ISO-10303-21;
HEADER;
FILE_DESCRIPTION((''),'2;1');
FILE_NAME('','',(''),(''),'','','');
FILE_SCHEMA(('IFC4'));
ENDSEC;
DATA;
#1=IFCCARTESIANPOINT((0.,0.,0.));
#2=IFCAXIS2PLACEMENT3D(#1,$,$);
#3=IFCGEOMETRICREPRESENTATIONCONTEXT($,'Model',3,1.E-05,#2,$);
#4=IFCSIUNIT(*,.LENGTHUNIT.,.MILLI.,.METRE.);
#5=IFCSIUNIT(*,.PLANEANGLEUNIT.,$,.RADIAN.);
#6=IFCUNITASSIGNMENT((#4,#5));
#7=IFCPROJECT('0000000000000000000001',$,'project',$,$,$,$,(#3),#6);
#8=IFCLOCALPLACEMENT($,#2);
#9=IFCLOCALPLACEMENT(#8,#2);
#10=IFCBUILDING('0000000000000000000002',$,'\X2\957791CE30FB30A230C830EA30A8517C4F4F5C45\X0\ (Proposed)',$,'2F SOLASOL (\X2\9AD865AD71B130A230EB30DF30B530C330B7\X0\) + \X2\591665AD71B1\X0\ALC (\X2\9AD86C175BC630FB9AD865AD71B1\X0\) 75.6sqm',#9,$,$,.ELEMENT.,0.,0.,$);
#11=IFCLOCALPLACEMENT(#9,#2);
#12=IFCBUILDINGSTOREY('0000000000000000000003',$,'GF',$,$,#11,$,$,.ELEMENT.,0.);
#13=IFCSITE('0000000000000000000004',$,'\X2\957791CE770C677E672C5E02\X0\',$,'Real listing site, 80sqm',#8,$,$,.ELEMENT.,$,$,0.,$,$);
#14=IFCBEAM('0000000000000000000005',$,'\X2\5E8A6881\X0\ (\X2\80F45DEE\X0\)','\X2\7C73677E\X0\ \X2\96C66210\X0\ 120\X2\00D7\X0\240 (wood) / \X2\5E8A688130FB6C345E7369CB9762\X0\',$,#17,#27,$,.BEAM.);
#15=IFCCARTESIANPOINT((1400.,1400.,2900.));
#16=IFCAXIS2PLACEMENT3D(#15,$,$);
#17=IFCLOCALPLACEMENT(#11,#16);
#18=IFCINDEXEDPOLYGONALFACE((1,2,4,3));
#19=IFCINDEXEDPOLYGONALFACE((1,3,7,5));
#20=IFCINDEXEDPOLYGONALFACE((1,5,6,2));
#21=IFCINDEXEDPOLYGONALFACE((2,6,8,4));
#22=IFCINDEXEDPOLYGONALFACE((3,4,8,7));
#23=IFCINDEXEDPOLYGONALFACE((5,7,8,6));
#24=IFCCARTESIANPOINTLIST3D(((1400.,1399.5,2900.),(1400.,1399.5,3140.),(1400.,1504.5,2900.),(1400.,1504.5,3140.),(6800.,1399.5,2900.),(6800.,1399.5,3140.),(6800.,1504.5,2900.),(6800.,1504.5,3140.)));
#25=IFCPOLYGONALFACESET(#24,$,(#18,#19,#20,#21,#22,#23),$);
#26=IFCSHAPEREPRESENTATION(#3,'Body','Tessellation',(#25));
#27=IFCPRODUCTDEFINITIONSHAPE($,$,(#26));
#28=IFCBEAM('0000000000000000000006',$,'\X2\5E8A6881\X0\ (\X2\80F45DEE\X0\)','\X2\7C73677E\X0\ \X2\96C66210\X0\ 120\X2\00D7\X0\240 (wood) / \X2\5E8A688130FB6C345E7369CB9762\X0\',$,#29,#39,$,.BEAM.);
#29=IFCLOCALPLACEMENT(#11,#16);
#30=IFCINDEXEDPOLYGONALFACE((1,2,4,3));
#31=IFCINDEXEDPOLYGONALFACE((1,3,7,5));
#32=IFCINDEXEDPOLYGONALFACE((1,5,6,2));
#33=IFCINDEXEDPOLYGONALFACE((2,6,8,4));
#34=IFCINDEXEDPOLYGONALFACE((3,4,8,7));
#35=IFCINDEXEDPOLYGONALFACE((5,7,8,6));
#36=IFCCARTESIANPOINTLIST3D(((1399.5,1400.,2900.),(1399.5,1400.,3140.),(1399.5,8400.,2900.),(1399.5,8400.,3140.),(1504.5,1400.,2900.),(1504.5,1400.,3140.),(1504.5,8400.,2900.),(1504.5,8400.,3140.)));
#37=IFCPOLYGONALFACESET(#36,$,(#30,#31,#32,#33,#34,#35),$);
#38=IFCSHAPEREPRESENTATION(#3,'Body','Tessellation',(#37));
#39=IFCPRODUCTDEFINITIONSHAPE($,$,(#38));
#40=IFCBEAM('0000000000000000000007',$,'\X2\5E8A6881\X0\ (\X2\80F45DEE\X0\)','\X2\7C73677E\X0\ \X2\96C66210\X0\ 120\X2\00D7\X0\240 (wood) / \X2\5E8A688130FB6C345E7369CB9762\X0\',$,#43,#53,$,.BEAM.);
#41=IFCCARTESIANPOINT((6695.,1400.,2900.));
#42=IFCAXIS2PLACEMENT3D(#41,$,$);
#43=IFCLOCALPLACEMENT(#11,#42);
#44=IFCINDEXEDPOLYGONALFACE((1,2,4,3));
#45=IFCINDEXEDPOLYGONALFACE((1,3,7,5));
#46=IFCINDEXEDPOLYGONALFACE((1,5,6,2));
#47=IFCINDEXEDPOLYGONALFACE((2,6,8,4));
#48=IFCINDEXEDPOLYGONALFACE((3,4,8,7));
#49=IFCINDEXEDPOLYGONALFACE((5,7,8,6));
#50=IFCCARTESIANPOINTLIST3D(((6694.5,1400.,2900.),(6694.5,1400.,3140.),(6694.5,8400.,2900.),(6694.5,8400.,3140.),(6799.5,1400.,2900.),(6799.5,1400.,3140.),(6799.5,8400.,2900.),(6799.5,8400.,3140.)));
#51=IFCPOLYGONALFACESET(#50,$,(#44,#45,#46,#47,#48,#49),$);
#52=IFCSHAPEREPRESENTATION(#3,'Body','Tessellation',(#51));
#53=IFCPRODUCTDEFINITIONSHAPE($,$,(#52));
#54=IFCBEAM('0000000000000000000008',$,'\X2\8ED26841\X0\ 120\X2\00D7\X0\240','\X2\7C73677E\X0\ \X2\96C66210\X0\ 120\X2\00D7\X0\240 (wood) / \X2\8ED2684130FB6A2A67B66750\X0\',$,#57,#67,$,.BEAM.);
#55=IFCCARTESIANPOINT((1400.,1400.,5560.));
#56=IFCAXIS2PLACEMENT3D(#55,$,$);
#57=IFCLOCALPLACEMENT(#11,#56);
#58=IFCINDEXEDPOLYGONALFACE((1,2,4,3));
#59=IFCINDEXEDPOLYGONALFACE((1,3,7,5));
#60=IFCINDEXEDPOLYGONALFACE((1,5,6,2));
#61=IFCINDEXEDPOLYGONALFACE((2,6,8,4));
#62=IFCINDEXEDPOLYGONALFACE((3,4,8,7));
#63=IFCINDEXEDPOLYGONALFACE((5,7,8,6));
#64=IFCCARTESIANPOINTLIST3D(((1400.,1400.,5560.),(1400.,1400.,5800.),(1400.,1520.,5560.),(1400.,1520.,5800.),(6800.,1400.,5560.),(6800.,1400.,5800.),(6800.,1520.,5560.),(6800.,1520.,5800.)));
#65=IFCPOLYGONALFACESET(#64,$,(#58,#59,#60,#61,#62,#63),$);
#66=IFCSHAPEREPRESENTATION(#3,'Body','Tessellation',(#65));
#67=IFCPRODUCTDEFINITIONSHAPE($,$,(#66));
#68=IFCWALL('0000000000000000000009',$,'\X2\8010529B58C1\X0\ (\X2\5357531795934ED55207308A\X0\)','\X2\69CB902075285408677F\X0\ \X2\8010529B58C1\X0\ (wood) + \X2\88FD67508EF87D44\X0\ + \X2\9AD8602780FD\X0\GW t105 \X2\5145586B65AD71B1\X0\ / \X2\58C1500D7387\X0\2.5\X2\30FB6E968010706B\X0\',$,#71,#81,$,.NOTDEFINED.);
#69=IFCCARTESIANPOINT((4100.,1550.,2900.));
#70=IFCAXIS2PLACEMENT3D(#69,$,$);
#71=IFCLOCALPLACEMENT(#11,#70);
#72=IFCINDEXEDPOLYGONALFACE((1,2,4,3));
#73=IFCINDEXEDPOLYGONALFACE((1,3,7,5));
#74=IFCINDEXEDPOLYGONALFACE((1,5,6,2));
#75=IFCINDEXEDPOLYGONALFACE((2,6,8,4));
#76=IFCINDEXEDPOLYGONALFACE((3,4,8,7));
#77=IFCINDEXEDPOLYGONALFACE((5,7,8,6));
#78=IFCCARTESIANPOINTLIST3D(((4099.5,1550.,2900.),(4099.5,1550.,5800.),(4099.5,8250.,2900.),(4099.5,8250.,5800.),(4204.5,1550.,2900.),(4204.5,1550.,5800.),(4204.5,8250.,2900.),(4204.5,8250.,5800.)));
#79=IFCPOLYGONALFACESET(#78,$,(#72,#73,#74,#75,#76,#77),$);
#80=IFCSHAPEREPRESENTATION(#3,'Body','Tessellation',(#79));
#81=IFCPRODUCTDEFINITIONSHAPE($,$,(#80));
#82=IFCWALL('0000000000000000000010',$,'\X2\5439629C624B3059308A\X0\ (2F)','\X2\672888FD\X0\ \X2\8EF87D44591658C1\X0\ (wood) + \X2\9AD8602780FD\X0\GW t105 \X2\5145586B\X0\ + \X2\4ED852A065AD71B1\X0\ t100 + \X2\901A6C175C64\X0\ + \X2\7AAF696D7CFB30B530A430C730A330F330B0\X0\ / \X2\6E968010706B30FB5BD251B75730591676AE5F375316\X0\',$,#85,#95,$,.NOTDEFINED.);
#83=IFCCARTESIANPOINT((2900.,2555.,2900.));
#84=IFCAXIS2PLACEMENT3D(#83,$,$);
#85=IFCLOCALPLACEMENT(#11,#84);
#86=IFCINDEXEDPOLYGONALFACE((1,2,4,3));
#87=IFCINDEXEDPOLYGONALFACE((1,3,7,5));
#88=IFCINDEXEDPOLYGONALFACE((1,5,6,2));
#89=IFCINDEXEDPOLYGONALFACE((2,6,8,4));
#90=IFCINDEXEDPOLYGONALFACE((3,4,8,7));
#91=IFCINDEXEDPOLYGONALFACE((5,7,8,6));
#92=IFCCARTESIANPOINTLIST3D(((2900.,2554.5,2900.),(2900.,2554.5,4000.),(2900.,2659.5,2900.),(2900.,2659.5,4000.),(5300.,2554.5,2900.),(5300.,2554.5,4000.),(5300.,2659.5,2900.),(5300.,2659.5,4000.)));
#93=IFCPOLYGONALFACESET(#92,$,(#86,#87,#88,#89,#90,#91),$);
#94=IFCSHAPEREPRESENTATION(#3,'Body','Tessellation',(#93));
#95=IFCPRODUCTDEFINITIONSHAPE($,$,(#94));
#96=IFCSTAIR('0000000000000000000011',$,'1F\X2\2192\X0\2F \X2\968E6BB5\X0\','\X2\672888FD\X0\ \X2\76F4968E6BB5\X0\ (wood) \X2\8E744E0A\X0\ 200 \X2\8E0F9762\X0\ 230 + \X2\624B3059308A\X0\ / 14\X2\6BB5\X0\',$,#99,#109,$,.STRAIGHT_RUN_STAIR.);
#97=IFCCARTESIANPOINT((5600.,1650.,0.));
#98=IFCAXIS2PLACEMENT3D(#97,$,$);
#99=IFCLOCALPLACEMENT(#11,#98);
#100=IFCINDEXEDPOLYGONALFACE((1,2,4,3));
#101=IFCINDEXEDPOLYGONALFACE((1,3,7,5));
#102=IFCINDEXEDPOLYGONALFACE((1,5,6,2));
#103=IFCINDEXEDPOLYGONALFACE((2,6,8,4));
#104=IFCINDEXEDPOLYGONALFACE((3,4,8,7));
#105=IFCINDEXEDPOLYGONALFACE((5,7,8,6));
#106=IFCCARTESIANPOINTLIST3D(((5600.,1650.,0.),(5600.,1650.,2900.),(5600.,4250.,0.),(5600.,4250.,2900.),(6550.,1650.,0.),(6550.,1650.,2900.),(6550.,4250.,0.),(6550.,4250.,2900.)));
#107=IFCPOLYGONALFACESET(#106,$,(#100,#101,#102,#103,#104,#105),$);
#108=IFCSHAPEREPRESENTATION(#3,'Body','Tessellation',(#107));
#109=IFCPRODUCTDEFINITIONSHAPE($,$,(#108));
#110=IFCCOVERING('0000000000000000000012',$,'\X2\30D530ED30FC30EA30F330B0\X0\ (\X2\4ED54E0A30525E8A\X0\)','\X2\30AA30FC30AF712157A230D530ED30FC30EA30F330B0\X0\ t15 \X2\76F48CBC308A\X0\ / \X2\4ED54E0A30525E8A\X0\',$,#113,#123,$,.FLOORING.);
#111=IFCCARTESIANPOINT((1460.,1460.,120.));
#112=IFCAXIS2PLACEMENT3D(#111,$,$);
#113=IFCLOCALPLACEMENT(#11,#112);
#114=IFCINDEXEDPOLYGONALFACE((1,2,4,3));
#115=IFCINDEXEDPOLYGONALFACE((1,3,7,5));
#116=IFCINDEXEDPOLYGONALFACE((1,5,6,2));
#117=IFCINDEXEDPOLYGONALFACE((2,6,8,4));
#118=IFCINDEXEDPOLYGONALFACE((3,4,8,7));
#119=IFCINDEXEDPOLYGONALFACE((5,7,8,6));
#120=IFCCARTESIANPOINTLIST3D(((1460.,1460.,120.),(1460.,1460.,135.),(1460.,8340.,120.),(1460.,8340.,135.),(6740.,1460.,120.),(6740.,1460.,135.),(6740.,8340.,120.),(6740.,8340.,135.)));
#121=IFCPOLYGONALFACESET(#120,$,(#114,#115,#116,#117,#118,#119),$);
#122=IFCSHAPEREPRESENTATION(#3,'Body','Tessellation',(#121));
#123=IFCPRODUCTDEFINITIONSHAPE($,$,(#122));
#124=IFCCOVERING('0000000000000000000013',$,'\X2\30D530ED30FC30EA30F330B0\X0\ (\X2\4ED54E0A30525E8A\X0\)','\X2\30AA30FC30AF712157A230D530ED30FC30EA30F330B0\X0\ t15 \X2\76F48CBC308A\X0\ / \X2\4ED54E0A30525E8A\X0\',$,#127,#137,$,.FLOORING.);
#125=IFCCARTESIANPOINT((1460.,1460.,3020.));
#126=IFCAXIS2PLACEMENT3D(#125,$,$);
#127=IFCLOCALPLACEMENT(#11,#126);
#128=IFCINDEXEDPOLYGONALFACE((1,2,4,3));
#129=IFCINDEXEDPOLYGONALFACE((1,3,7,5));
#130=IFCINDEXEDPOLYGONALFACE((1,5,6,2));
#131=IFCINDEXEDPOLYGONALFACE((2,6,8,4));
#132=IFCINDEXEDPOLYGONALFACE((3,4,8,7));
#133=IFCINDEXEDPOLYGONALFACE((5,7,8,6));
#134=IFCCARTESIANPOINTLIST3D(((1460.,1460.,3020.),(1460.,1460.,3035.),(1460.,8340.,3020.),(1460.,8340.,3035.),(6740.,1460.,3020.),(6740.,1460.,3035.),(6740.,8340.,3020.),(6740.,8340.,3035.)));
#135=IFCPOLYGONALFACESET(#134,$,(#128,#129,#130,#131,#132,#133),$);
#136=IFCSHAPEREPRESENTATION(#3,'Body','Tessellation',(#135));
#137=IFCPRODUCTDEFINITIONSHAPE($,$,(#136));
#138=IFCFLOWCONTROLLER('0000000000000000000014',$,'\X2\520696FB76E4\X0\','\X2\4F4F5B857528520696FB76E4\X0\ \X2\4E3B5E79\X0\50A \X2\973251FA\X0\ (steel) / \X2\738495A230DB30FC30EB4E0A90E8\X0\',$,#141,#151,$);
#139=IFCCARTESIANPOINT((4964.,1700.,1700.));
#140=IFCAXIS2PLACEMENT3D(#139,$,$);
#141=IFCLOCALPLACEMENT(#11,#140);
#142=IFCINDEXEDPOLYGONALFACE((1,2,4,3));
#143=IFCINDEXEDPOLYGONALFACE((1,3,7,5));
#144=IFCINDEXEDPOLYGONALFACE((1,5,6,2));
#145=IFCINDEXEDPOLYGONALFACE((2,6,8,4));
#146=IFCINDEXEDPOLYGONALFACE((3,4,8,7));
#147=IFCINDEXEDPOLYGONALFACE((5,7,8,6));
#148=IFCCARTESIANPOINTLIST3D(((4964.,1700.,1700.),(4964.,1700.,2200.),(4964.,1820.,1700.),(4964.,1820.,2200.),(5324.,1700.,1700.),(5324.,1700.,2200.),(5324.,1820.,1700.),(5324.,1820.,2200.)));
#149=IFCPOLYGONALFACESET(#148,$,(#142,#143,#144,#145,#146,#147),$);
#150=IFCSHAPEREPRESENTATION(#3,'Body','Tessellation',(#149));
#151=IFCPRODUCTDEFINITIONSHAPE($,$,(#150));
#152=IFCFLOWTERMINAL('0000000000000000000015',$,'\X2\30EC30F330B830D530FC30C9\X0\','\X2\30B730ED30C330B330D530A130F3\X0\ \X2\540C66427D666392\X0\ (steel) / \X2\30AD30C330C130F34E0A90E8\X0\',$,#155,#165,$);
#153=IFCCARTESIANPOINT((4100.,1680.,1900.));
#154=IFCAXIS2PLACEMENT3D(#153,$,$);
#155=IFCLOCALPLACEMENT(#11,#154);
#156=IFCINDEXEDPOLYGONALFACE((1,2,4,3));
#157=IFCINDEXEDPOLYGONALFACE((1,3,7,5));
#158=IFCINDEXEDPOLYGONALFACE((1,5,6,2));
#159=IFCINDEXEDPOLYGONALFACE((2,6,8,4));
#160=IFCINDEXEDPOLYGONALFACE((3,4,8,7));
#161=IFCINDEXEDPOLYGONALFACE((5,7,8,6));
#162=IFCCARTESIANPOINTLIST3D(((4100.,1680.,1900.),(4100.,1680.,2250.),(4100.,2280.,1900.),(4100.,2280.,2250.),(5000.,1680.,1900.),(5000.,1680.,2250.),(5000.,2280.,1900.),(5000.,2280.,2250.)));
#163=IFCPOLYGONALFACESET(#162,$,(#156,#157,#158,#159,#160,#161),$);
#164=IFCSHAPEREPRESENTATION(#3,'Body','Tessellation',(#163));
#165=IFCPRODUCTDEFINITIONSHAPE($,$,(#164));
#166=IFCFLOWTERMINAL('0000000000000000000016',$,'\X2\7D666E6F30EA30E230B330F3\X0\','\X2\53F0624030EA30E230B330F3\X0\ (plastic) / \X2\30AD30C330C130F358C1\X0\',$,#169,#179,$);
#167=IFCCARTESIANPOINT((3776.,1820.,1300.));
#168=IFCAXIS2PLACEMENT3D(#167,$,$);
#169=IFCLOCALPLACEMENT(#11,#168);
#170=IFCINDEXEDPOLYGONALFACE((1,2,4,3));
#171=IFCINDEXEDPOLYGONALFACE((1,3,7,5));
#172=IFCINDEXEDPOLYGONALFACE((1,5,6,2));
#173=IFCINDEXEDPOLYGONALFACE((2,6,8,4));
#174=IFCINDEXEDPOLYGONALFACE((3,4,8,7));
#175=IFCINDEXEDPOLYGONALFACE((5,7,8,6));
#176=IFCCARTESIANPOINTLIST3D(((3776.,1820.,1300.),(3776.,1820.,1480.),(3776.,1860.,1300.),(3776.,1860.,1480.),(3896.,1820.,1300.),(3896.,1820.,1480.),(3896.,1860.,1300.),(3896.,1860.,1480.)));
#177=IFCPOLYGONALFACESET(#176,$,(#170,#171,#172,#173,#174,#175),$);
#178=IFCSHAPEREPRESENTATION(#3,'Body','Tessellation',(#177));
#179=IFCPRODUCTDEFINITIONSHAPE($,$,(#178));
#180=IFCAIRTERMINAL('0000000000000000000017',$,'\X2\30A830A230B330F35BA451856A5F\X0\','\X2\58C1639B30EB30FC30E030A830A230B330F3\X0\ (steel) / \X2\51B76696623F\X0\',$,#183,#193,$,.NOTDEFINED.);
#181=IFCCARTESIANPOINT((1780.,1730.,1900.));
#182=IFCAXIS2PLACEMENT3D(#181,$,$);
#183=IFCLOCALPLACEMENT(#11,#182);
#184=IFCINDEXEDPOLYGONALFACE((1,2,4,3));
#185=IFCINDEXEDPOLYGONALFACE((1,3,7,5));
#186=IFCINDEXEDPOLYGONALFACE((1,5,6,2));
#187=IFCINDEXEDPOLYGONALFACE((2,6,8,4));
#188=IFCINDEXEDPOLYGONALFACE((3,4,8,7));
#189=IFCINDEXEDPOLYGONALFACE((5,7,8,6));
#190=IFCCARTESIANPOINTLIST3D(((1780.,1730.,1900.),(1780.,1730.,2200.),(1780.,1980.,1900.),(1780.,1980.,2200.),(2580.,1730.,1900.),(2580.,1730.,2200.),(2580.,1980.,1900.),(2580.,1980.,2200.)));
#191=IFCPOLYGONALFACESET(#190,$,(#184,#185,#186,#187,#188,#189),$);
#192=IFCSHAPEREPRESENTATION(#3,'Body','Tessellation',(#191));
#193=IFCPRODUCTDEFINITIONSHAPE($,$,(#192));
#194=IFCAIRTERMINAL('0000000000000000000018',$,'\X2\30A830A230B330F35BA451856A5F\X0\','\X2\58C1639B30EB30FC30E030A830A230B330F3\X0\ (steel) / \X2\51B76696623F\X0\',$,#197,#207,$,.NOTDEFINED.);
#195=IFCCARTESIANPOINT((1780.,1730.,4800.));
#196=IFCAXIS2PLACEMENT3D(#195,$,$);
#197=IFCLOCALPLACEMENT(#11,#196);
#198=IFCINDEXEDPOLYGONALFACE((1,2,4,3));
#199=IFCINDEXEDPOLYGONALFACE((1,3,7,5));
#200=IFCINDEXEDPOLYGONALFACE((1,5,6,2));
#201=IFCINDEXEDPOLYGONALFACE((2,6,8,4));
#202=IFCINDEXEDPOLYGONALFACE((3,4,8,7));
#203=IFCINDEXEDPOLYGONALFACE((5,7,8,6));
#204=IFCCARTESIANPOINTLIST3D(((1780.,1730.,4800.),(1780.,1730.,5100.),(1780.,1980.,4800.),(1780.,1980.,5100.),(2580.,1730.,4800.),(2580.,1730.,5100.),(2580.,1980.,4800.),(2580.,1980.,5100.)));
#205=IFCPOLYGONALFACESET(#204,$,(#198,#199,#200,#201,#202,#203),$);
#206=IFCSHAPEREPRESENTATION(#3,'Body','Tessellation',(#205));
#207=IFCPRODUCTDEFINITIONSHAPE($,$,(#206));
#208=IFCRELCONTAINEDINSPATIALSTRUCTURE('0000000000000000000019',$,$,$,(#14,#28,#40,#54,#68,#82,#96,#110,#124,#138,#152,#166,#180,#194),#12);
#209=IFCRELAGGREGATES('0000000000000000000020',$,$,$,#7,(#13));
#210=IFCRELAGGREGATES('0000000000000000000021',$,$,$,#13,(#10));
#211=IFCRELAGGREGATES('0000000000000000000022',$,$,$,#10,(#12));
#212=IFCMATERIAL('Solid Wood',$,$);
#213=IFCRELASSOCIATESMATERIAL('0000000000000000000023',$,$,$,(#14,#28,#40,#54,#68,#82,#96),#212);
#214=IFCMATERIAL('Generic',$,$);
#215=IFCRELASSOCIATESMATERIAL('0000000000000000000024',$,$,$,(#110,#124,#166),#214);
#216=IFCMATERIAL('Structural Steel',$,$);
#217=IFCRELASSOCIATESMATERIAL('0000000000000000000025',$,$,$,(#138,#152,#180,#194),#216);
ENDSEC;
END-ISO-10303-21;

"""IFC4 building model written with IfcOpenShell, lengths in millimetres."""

from ifc_helpers import new_model, si_unit, frame, frame_2d, origin, place, context, project, spatial, rectangle, extrude, material, element, save


model = new_model("IFC4")

# Units and contexts
model_context = context("Model", 3, precision=1e-05, world=origin())
ifc_project = project(units=[si_unit("LENGTHUNIT", "METRE", prefix="MILLI"), si_unit("PLANEANGLEUNIT", "RADIAN")], contexts=[model_context])

# Site, building, storey
site_placement = place(None, origin())
site = spatial("IfcSite", under=ifc_project, at=site_placement, Name="長野県松本市", ObjectType="Real listing site, 80sqm", CompositionType="ELEMENT", RefElevation=0.0)
building_placement = place(site_placement, origin())
building = spatial("IfcBuilding", under=site, at=building_placement, Name="長野・アトリエ兼住居 (Proposed)", ObjectType="2F SOLASOL (高断熱アルミサッシ) + 外断熱ALC (高気密・高断熱) 75.6sqm", CompositionType="ELEMENT", ElevationOfRefHeight=0.0, ElevationOfTerrain=0.0)
storey_placement = place(building_placement, origin())
storey = spatial("IfcBuildingStorey", under=building, at=storey_placement, Name="GF", CompositionType="ELEMENT", Elevation=0.0)

# Shared definitions
ifc_material_1 = material(Name="Solid Wood")

# Beams
beam_1_placement = place(storey_placement, frame((1400.0, 1400.0, 2900.0)))
element("IfcBeam", 1, at=beam_1_placement, inside=storey, material=ifc_material_1, Name="床梁 (胴差)", Description="米松 集成 120×240 (wood) / 床梁・水平構面", PredefinedType="BEAM", context=model_context, shape_type="SweptSolid", body=[
    extrude(rectangle(XDim=5400.0, YDim=105.0, at=frame_2d((2700.0, 52.0))), frame((1400.0, 1400.0, 2900.0)), (0.0, 0.0, 1.0), 240.0),
])
beam_2_placement = place(storey_placement, frame((1400.0, 1400.0, 2900.0)))
element("IfcBeam", 2, at=beam_2_placement, inside=storey, material=ifc_material_1, Name="床梁 (胴差)", Description="米松 集成 120×240 (wood) / 床梁・水平構面", PredefinedType="BEAM", context=model_context, shape_type="SweptSolid", body=[
    extrude(rectangle(XDim=105.0, YDim=7000.0, at=frame_2d((52.0, 3500.0))), frame((1400.0, 1400.0, 2900.0)), (0.0, 0.0, 1.0), 240.0),
])
beam_3_placement = place(storey_placement, frame((6695.0, 1400.0, 2900.0)))
element("IfcBeam", 3, at=beam_3_placement, inside=storey, material=ifc_material_1, Name="床梁 (胴差)", Description="米松 集成 120×240 (wood) / 床梁・水平構面", PredefinedType="BEAM", context=model_context, shape_type="SweptSolid", body=[
    extrude(rectangle(XDim=105.0, YDim=7000.0, at=frame_2d((52.0, 3500.0))), frame((6695.0, 1400.0, 2900.0)), (0.0, 0.0, 1.0), 240.0),
])
beam_4_placement = place(storey_placement, frame((1400.0, 1400.0, 5560.0)))
element("IfcBeam", 4, at=beam_4_placement, inside=storey, material=ifc_material_1, Name="軒桁 120×240", Description="米松 集成 120×240 (wood) / 軒桁・横架材", PredefinedType="BEAM", context=model_context, shape_type="SweptSolid", body=[
    extrude(rectangle(XDim=5400.0, YDim=120.0, at=frame_2d((2700.0, 60.0))), frame((1400.0, 1400.0, 5560.0)), (0.0, 0.0, 1.0), 240.0),
])

# Walls
wall_1_placement = place(storey_placement, frame((4100.0, 1550.0, 2900.0)))
element("IfcWall", 5, at=wall_1_placement, inside=storey, material=ifc_material_1, Name="耐力壁 (南北間仕切り)", Description="構造用合板 耐力壁 (wood) + 製材軸組 + 高性能GW t105 充填断熱 / 壁倍率2.5・準耐火", PredefinedType="NOTDEFINED", context=model_context, shape_type="SweptSolid", body=[
    extrude(rectangle(XDim=105.0, YDim=6700.0, at=frame_2d((52.0, 3350.0))), frame((4100.0, 1550.0, 2900.0)), (0.0, 0.0, 1.0), 2900.0),
])
wall_2_placement = place(storey_placement, frame((2900.0, 2555.0, 2900.0)))
element("IfcWall", 6, at=wall_2_placement, inside=storey, material=ifc_material_1, Name="吹抜手すり (2F)", Description="木製 軸組外壁 (wood) + 高性能GW t105 充填 + 付加断熱 t100 + 通気層 + 窯業系サイディング / 準耐火・寒冷地外皮強化", PredefinedType="NOTDEFINED", context=model_context, shape_type="SweptSolid", body=[
    extrude(rectangle(XDim=2400.0, YDim=105.0, at=frame_2d((1200.0, 52.0))), frame((2900.0, 2555.0, 2900.0)), (0.0, 0.0, 1.0), 1100.0),
])

# Stair
stair_placement = place(storey_placement, frame((5600.0, 1650.0, 0.0)))
element("IfcStair", 7, at=stair_placement, inside=storey, material=ifc_material_1, Name="1F→2F 階段", Description="木製 直階段 (wood) 蹴上 200 踏面 230 + 手すり / 14段", PredefinedType="STRAIGHT_RUN_STAIR", context=model_context, shape_type="SweptSolid", body=[
    extrude(rectangle(XDim=950.0, YDim=2600.0, at=frame_2d((475.0, 1300.0))), frame((5600.0, 1650.0, 0.0)), (0.0, 0.0, 1.0), 2900.0),
])

# Coverings
ifc_material_2 = material(Name="Generic")
covering_1_placement = place(storey_placement, frame((1460.0, 1460.0, 120.0)))
element("IfcCovering", 8, at=covering_1_placement, inside=storey, material=ifc_material_2, Name="フローリング (仕上げ床)", Description="オーク無垢フローリング t15 直貼り / 仕上げ床", PredefinedType="FLOORING", context=model_context, shape_type="SweptSolid", body=[
    extrude(rectangle(XDim=5280.0, YDim=6880.0, at=frame_2d((2640.0, 3440.0))), frame((1460.0, 1460.0, 120.0)), (0.0, 0.0, 1.0), 15.0),
])
covering_2_placement = place(storey_placement, frame((1460.0, 1460.0, 3020.0)))
element("IfcCovering", 9, at=covering_2_placement, inside=storey, material=ifc_material_2, Name="フローリング (仕上げ床)", Description="オーク無垢フローリング t15 直貼り / 仕上げ床", PredefinedType="FLOORING", context=model_context, shape_type="SweptSolid", body=[
    extrude(rectangle(XDim=5280.0, YDim=6880.0, at=frame_2d((2640.0, 3440.0))), frame((1460.0, 1460.0, 3020.0)), (0.0, 0.0, 1.0), 15.0),
])

# Flow controller
ifc_material_3 = material(Name="Structural Steel")
flow_controller_placement = place(storey_placement, frame((4964.0, 1700.0, 1700.0)))
element("IfcFlowController", 10, at=flow_controller_placement, inside=storey, material=ifc_material_3, Name="分電盤", Description="住宅用分電盤 主幹50A 露出 (steel) / 玄関ホール上部", context=model_context, shape_type="SweptSolid", body=[
    extrude(rectangle(XDim=360.0, YDim=120.0, at=frame_2d((180.0, 60.0))), frame((4964.0, 1700.0, 1700.0)), (0.0, 0.0, 1.0), 500.0),
])

# Flow terminals
flow_terminal_1_placement = place(storey_placement, frame((4100.0, 1680.0, 1900.0)))
element("IfcFlowTerminal", 11, at=flow_terminal_1_placement, inside=storey, material=ifc_material_3, Name="レンジフード", Description="シロッコファン 同時給排 (steel) / キッチン上部", context=model_context, shape_type="SweptSolid", body=[
    extrude(rectangle(XDim=900.0, YDim=600.0, at=frame_2d((450.0, 300.0))), frame((4100.0, 1680.0, 1900.0)), (0.0, 0.0, 1.0), 350.0),
])
flow_terminal_2_placement = place(storey_placement, frame((3776.0, 1820.0, 1300.0)))
element("IfcFlowTerminal", 12, at=flow_terminal_2_placement, inside=storey, material=ifc_material_2, Name="給湯リモコン", Description="台所リモコン (plastic) / キッチン壁", context=model_context, shape_type="SweptSolid", body=[
    extrude(rectangle(XDim=120.0, YDim=40.0, at=frame_2d((60.0, 20.0))), frame((3776.0, 1820.0, 1300.0)), (0.0, 0.0, 1.0), 180.0),
])

# Air terminals
air_terminal_1_placement = place(storey_placement, frame((1780.0, 1730.0, 1900.0)))
element("IfcAirTerminal", 13, at=air_terminal_1_placement, inside=storey, material=ifc_material_3, Name="エアコン室内機", Description="壁掛ルームエアコン (steel) / 冷暖房", PredefinedType="NOTDEFINED", context=model_context, shape_type="SweptSolid", body=[
    extrude(rectangle(XDim=800.0, YDim=250.0, at=frame_2d((400.0, 125.0))), frame((1780.0, 1730.0, 1900.0)), (0.0, 0.0, 1.0), 300.0),
])
air_terminal_2_placement = place(storey_placement, frame((1780.0, 1730.0, 4800.0)))
element("IfcAirTerminal", 14, at=air_terminal_2_placement, inside=storey, material=ifc_material_3, Name="エアコン室内機", Description="壁掛ルームエアコン (steel) / 冷暖房", PredefinedType="NOTDEFINED", context=model_context, shape_type="SweptSolid", body=[
    extrude(rectangle(XDim=800.0, YDim=250.0, at=frame_2d((400.0, 125.0))), frame((1780.0, 1730.0, 4800.0)), (0.0, 0.0, 1.0), 300.0),
])

save(model, "model.ifc")
